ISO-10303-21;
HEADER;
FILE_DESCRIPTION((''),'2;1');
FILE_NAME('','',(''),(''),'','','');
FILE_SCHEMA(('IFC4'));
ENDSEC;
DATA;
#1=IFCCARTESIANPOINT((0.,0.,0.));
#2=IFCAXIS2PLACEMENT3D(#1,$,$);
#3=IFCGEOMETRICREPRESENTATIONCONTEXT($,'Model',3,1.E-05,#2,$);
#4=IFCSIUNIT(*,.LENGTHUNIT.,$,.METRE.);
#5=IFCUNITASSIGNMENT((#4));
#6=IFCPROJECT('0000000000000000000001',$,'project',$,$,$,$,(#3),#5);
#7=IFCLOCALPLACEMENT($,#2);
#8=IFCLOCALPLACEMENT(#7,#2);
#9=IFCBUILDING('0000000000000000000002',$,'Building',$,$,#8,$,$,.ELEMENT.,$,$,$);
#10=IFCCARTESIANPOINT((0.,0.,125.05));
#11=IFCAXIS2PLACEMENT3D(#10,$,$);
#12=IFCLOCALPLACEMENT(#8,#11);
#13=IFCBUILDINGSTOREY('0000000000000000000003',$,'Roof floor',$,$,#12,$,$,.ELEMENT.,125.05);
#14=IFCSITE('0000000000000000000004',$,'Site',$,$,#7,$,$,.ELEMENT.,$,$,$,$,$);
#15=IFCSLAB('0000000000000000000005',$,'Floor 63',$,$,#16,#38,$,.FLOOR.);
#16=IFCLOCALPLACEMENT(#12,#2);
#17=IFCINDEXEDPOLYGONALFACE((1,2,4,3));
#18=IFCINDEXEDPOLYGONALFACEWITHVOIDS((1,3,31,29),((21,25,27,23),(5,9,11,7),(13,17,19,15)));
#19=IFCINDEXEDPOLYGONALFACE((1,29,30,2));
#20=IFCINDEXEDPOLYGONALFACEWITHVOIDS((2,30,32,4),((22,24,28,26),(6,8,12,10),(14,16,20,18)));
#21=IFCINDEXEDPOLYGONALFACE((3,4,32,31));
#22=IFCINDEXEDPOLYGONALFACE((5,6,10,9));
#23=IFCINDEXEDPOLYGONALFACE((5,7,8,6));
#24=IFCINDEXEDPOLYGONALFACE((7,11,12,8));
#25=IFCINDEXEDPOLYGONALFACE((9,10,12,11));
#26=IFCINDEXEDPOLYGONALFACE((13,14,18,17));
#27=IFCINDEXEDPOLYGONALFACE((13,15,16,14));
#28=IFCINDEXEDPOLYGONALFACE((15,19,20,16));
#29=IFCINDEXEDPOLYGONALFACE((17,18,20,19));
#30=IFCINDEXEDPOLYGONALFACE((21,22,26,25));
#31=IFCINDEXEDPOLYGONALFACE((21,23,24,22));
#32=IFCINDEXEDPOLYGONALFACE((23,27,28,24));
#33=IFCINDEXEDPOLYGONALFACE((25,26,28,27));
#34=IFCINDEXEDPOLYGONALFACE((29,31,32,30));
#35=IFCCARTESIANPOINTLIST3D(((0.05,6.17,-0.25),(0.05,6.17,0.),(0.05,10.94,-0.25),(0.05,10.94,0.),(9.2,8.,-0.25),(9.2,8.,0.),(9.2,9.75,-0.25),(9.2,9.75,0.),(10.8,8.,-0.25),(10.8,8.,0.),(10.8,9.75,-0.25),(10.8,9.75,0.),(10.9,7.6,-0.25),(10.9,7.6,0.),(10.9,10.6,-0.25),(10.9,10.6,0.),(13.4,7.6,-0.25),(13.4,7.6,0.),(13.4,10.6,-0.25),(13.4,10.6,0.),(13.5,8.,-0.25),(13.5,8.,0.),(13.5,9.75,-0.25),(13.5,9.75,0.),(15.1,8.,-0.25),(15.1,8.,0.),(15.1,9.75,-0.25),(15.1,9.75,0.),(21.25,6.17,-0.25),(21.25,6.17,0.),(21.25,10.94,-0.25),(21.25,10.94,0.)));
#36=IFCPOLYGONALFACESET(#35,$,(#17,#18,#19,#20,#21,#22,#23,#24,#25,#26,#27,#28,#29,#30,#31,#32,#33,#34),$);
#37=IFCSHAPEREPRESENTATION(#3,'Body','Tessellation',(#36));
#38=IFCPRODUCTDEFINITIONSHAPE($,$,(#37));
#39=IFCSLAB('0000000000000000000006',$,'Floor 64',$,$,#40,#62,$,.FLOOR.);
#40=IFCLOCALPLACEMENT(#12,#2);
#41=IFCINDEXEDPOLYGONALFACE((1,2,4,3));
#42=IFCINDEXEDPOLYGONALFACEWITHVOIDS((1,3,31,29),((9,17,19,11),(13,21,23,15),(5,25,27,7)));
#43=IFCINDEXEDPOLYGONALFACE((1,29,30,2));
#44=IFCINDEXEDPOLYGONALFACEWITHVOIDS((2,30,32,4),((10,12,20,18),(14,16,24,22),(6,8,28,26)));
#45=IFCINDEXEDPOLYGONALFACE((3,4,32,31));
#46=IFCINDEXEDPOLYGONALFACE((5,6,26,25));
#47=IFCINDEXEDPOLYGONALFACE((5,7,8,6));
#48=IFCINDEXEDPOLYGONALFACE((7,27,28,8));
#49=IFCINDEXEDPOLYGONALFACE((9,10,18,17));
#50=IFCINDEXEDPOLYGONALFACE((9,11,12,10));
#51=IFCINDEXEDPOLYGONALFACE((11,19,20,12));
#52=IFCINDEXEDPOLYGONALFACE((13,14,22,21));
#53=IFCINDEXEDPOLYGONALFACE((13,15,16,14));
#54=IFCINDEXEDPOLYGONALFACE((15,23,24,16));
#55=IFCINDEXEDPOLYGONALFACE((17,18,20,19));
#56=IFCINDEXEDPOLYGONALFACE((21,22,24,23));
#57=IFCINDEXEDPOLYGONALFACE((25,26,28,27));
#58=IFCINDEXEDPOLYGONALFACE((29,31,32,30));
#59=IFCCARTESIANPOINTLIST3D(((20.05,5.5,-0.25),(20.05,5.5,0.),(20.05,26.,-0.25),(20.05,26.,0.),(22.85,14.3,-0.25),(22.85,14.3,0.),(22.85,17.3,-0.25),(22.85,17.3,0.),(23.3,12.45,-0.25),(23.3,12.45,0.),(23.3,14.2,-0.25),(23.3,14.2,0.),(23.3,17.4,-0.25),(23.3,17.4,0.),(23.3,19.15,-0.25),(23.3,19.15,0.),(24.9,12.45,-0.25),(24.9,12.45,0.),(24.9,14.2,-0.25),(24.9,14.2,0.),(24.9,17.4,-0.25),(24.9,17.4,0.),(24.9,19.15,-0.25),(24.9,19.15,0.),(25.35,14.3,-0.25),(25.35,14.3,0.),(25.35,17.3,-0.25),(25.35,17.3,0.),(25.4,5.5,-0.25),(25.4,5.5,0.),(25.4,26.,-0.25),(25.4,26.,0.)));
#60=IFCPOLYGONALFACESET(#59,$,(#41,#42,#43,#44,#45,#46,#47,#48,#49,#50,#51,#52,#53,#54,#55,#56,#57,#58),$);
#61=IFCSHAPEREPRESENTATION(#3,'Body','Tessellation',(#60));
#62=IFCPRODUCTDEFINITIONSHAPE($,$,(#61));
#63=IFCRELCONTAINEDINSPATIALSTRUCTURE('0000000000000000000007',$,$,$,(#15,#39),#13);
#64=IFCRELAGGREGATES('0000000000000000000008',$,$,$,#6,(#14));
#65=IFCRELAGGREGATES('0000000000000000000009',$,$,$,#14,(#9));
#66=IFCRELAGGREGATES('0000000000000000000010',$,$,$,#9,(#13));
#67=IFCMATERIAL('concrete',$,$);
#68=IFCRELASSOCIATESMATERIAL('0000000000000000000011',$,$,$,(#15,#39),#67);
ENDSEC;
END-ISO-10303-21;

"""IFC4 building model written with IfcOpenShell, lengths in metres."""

from ifc_helpers import new_model, si_unit, frame, origin, place, context, project, spatial, polyline, outline, extrude, material, element, save


model = new_model("IFC4")

# Units and contexts
model_context = context("Model", 3, precision=1e-05, world=origin())
ifc_project = project(units=[si_unit("LENGTHUNIT", "METRE")], contexts=[model_context])

# Site, building, storey
site_placement = place(None, origin())
site = spatial("IfcSite", under=ifc_project, at=site_placement, Name="Site", CompositionType="ELEMENT")
building_placement = place(site_placement, origin())
building = spatial("IfcBuilding", under=site, at=building_placement, Name="Building", CompositionType="ELEMENT")
storey_placement = place(building_placement, frame((0.0, 0.0, 125.05)))
storey = spatial("IfcBuildingStorey", under=building, at=storey_placement, Name="Roof floor", CompositionType="ELEMENT", Elevation=125.05)

# Slabs
ifc_material = material(Name="concrete")
slab_1_placement = place(storey_placement, frame((0.0, 0.0, -0.25), z_axis=(0.0, 0.0, 1.0), x_axis=(1.0, 0.0, 0.0)))
element("IfcSlab", 1, at=slab_1_placement, inside=storey, material=ifc_material, Name="Floor 63", PredefinedType="FLOOR", context=model_context, shape_type="SweptSolid", body=[
    extrude(outline(polyline([(0.05, 6.17), (21.25, 6.17), (21.25, 10.94), (0.05, 10.94), (0.05, 6.17)]), holes=[polyline([(10.9, 7.6), (13.4, 7.6), (13.4, 10.6), (10.9, 10.6), (10.9, 7.6)]), polyline([(9.2, 8.0), (10.8, 8.0), (10.8, 9.75), (9.2, 9.75), (9.2, 8.0)]), polyline([(13.5, 8.0), (15.1, 8.0), (15.1, 9.75), (13.5, 9.75), (13.5, 8.0)])]), origin(), (0.0, 0.0, 1.0), 0.25),
])
slab_2_placement = place(storey_placement, frame((0.0, 0.0, -0.25), z_axis=(0.0, 0.0, 1.0), x_axis=(1.0, 0.0, 0.0)))
element("IfcSlab", 2, at=slab_2_placement, inside=storey, material=ifc_material, Name="Floor 64", PredefinedType="FLOOR", context=model_context, shape_type="SweptSolid", body=[
    extrude(outline(polyline([(20.05, 5.5), (25.4, 5.5), (25.4, 26.0), (20.05, 26.0), (20.05, 5.5)]), holes=[polyline([(22.85, 14.3), (25.35, 14.3), (25.35, 17.3), (22.85, 17.3), (22.85, 14.3)]), polyline([(23.3, 17.4), (24.9, 17.4), (24.9, 19.15), (23.3, 19.15), (23.3, 17.4)]), polyline([(23.3, 12.45), (24.9, 12.45), (24.9, 14.2), (23.3, 14.2), (23.3, 12.45)])]), origin(), (0.0, 0.0, 1.0), 0.25),
])

save(model, "model.ifc")
